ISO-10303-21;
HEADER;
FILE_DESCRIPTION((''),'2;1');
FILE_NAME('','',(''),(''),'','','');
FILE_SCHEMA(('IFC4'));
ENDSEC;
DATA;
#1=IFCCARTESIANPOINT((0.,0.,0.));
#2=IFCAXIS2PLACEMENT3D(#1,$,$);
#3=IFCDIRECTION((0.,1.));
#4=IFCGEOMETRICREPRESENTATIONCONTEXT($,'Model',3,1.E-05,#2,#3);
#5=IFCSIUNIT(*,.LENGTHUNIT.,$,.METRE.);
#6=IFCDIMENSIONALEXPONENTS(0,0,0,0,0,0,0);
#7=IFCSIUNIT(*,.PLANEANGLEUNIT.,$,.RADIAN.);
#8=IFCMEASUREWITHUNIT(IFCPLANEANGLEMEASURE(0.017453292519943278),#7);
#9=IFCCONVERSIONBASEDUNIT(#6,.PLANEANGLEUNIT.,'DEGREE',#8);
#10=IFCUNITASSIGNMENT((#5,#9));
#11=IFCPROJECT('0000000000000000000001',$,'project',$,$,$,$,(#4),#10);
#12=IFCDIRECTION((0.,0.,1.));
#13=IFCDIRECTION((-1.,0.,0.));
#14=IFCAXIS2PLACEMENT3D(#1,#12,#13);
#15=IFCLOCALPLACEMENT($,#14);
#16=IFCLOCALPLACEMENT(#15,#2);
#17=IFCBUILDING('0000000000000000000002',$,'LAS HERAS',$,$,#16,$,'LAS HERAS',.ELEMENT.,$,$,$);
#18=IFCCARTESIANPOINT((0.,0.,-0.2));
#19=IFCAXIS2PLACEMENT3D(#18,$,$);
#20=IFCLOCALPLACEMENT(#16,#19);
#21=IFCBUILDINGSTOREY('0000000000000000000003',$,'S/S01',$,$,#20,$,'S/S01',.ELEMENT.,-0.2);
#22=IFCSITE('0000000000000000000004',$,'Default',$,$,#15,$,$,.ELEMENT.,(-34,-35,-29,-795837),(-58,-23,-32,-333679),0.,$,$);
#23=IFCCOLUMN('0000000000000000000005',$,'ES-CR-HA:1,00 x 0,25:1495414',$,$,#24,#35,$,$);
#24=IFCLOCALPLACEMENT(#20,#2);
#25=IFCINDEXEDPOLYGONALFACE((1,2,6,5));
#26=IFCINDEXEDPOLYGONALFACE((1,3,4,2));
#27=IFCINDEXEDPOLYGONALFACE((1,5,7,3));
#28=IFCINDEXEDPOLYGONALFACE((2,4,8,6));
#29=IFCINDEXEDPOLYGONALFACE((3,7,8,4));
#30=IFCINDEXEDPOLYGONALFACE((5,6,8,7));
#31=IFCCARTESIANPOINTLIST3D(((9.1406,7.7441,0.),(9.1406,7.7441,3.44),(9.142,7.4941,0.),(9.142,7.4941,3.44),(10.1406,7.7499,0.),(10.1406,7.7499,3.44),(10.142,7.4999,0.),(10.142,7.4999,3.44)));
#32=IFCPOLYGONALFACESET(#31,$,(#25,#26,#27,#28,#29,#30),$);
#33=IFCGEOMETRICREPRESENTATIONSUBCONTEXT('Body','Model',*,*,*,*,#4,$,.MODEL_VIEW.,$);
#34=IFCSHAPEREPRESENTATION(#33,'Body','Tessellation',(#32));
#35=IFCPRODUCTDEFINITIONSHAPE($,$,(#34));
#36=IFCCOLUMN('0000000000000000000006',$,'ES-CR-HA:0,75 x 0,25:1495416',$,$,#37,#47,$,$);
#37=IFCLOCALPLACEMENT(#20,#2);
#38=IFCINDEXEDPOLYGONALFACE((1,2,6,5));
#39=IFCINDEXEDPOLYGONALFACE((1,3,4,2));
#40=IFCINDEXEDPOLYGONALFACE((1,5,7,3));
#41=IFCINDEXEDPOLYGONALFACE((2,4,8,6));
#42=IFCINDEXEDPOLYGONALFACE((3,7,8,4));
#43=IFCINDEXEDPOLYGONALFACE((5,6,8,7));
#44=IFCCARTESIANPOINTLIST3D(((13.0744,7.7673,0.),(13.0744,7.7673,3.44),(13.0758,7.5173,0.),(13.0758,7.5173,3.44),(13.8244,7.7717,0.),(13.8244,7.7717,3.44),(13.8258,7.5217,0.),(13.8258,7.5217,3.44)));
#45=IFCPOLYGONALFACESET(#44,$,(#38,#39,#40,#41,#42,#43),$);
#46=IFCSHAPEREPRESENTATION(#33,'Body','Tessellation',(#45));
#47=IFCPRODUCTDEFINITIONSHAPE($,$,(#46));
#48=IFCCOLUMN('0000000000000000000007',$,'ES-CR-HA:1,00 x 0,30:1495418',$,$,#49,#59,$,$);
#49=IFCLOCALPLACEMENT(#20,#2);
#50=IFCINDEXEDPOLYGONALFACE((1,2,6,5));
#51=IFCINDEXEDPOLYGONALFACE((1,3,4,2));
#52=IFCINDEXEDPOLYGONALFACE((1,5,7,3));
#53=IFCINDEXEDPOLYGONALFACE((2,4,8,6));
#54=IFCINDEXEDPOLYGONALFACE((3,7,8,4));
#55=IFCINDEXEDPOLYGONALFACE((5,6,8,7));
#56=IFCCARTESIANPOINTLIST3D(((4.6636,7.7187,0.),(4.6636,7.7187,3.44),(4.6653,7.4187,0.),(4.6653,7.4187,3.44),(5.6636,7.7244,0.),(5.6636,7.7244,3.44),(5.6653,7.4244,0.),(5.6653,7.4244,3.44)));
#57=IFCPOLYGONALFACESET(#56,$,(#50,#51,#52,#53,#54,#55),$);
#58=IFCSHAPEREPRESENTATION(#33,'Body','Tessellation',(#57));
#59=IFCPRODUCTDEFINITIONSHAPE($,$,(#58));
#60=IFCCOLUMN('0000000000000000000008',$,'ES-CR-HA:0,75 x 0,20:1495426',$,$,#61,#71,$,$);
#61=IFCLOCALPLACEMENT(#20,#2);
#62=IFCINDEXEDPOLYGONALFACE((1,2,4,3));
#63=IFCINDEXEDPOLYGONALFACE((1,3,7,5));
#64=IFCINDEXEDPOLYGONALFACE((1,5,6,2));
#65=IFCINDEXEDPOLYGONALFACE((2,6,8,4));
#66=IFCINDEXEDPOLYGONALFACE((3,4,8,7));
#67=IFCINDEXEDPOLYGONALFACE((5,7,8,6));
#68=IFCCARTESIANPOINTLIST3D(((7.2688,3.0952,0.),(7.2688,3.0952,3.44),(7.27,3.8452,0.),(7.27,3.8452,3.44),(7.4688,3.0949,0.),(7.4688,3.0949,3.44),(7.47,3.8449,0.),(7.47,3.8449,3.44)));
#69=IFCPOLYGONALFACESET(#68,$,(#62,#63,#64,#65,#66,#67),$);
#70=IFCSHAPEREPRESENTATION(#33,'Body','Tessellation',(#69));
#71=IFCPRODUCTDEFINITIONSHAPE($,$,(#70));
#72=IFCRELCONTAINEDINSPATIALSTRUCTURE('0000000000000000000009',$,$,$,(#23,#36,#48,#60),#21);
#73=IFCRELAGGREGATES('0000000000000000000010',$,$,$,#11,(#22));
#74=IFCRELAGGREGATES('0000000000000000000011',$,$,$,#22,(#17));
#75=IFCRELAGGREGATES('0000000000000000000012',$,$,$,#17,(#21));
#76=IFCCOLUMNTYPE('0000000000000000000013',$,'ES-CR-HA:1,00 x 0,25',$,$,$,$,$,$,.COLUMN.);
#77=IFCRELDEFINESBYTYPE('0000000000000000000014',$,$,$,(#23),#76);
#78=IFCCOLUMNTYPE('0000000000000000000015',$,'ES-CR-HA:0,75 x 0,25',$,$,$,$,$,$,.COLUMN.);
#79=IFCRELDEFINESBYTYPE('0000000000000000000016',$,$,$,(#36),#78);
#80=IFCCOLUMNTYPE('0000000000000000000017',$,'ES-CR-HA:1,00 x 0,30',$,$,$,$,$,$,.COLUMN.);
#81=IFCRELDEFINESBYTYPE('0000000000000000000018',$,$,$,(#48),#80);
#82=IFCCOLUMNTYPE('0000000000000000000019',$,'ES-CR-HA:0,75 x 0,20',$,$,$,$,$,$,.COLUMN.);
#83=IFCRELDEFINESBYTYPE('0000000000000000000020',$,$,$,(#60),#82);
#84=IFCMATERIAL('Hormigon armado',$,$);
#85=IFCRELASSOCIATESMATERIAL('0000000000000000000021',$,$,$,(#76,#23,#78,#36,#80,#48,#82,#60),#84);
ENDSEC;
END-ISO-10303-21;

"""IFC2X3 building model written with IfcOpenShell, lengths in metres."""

from ifc_helpers import new_model, entity, si_unit, converted_unit, direction, frame, frame_2d, origin, origin_2d_with_axis, place, context, subcontext, project, spatial, rectangle, extrude, source, transform, mapped, material, type_object, type_shapes, element, save


model = new_model("IFC2X3")

# Units and contexts
model_context = context("Model", 3, precision=1e-05, world=origin(), true_north=direction((0.0, 1.0)))
body_context = subcontext(model_context, "Body", "Model", "MODEL_VIEW")
ifc_project = project(units=[si_unit("LENGTHUNIT", "METRE"), converted_unit("PLANEANGLEUNIT", "DEGREE", entity("IfcPlaneAngleMeasure", 0.017453292519943278), si_unit("PLANEANGLEUNIT", "RADIAN"), dimensions=[0, 0, 0, 0, 0, 0, 0])], contexts=[model_context])

# Site, building, storey
site_placement = place(None, frame((0.0, 0.0, 0.0), z_axis=(0.0, 0.0, 1.0), x_axis=(-1.0, 0.0, 0.0)))
site = spatial("IfcSite", under=ifc_project, at=site_placement, Name="Default", CompositionType="ELEMENT", RefLatitude=(-34, -35, -29, -795837), RefLongitude=(-58, -23, -32, -333679), RefElevation=0.0)
building_placement = place(site_placement, origin())
building = spatial("IfcBuilding", under=site, at=building_placement, Name="LAS HERAS", LongName="LAS HERAS", CompositionType="ELEMENT")
storey_placement = place(building_placement, frame((0.0, 0.0, -0.2)))
storey = spatial("IfcBuildingStorey", under=building, at=storey_placement, Name="S/S01", LongName="S/S01", CompositionType="ELEMENT", Elevation=-0.2)

# Columns
ifc_material = material(Name="Hormigon armado")
column_type_1 = type_object("IfcColumnType", Name="ES-CR-HA:1,00 x 0,25", PredefinedType="COLUMN", material=ifc_material)
shared_shape_1 = source(origin(), body_context, "Body", "SweptSolid", [
    extrude(rectangle(XDim=1.0, YDim=0.25, at=frame_2d((0.0, 0.0), x_axis=(1.0, 0.0))), frame((9.6413, 7.622, -0.2), z_axis=(0.0, 0.0, 1.0), x_axis=(-0.999983, -0.005788, 0.0)), (0.0, 0.0, 1.0), 3.44),
])
type_shapes(column_type_1, [shared_shape_1])
column_1_placement = place(storey_placement, frame((0.0, 0.0, 0.2)))
element("IfcColumn", 1, at=column_1_placement, inside=storey, type_object=column_type_1, material=ifc_material, Name="ES-CR-HA:1,00 x 0,25:1495414", context=body_context, shape_type="MappedRepresentation", body=[
    mapped(shared_shape_1, transform((0.0, 0.0, 0.0), scale=1.0)),
])
column_type_2 = type_object("IfcColumnType", Name="ES-CR-HA:0,75 x 0,25", PredefinedType="COLUMN", material=ifc_material)
shared_shape_2 = source(origin(), body_context, "Body", "SweptSolid", [
    extrude(rectangle(XDim=0.75, YDim=0.25, at=origin_2d_with_axis()), frame((13.4501, 7.6445, -0.2), z_axis=(0.0, 0.0, 1.0), x_axis=(-0.999983, -0.005788, 0.0)), (0.0, 0.0, 1.0), 3.44),
])
type_shapes(column_type_2, [shared_shape_2])
column_2_placement = place(storey_placement, frame((0.0, 0.0, 0.2)))
element("IfcColumn", 2, at=column_2_placement, inside=storey, type_object=column_type_2, material=ifc_material, Name="ES-CR-HA:0,75 x 0,25:1495416", context=body_context, shape_type="MappedRepresentation", body=[
    mapped(shared_shape_2, transform((0.0, 0.0, 0.0), scale=1.0)),
])
column_type_3 = type_object("IfcColumnType", Name="ES-CR-HA:1,00 x 0,30", PredefinedType="COLUMN", material=ifc_material)
shared_shape_3 = source(origin(), body_context, "Body", "SweptSolid", [
    extrude(rectangle(XDim=1.0, YDim=0.3, at=frame_2d((0.0, 0.0), x_axis=(1.0, 0.0))), frame((5.1645, 7.5715, -0.2), z_axis=(0.0, 0.0, 1.0), x_axis=(-0.999983, -0.005788, 0.0)), (0.0, 0.0, 1.0), 3.44),
])
type_shapes(column_type_3, [shared_shape_3])
column_3_placement = place(storey_placement, frame((0.0, 0.0, 0.2)))
element("IfcColumn", 3, at=column_3_placement, inside=storey, type_object=column_type_3, material=ifc_material, Name="ES-CR-HA:1,00 x 0,30:1495418", context=body_context, shape_type="MappedRepresentation", body=[
    mapped(shared_shape_3, transform((0.0, 0.0, 0.0), scale=1.0)),
])
column_type_4 = type_object("IfcColumnType", Name="ES-CR-HA:0,75 x 0,20", PredefinedType="COLUMN", material=ifc_material)
shared_shape_4 = source(origin(), body_context, "Body", "SweptSolid", [
    extrude(rectangle(XDim=0.75, YDim=0.2, at=frame_2d((0.0, 0.0), x_axis=(1.0, 0.0))), frame((7.3694, 3.4701, -0.2), z_axis=(0.0, 0.0, 1.0), x_axis=(-0.001607, -0.999999, 0.0)), (0.0, 0.0, 1.0), 3.44),
])
type_shapes(column_type_4, [shared_shape_4])
column_4_placement = place(storey_placement, frame((0.0, 0.0, 0.2)))
element("IfcColumn", 4, at=column_4_placement, inside=storey, type_object=column_type_4, material=ifc_material, Name="ES-CR-HA:0,75 x 0,20:1495426", context=body_context, shape_type="MappedRepresentation", body=[
    mapped(shared_shape_4, transform((0.0, 0.0, 0.0), scale=1.0)),
])

save(model, "model.ifc")
